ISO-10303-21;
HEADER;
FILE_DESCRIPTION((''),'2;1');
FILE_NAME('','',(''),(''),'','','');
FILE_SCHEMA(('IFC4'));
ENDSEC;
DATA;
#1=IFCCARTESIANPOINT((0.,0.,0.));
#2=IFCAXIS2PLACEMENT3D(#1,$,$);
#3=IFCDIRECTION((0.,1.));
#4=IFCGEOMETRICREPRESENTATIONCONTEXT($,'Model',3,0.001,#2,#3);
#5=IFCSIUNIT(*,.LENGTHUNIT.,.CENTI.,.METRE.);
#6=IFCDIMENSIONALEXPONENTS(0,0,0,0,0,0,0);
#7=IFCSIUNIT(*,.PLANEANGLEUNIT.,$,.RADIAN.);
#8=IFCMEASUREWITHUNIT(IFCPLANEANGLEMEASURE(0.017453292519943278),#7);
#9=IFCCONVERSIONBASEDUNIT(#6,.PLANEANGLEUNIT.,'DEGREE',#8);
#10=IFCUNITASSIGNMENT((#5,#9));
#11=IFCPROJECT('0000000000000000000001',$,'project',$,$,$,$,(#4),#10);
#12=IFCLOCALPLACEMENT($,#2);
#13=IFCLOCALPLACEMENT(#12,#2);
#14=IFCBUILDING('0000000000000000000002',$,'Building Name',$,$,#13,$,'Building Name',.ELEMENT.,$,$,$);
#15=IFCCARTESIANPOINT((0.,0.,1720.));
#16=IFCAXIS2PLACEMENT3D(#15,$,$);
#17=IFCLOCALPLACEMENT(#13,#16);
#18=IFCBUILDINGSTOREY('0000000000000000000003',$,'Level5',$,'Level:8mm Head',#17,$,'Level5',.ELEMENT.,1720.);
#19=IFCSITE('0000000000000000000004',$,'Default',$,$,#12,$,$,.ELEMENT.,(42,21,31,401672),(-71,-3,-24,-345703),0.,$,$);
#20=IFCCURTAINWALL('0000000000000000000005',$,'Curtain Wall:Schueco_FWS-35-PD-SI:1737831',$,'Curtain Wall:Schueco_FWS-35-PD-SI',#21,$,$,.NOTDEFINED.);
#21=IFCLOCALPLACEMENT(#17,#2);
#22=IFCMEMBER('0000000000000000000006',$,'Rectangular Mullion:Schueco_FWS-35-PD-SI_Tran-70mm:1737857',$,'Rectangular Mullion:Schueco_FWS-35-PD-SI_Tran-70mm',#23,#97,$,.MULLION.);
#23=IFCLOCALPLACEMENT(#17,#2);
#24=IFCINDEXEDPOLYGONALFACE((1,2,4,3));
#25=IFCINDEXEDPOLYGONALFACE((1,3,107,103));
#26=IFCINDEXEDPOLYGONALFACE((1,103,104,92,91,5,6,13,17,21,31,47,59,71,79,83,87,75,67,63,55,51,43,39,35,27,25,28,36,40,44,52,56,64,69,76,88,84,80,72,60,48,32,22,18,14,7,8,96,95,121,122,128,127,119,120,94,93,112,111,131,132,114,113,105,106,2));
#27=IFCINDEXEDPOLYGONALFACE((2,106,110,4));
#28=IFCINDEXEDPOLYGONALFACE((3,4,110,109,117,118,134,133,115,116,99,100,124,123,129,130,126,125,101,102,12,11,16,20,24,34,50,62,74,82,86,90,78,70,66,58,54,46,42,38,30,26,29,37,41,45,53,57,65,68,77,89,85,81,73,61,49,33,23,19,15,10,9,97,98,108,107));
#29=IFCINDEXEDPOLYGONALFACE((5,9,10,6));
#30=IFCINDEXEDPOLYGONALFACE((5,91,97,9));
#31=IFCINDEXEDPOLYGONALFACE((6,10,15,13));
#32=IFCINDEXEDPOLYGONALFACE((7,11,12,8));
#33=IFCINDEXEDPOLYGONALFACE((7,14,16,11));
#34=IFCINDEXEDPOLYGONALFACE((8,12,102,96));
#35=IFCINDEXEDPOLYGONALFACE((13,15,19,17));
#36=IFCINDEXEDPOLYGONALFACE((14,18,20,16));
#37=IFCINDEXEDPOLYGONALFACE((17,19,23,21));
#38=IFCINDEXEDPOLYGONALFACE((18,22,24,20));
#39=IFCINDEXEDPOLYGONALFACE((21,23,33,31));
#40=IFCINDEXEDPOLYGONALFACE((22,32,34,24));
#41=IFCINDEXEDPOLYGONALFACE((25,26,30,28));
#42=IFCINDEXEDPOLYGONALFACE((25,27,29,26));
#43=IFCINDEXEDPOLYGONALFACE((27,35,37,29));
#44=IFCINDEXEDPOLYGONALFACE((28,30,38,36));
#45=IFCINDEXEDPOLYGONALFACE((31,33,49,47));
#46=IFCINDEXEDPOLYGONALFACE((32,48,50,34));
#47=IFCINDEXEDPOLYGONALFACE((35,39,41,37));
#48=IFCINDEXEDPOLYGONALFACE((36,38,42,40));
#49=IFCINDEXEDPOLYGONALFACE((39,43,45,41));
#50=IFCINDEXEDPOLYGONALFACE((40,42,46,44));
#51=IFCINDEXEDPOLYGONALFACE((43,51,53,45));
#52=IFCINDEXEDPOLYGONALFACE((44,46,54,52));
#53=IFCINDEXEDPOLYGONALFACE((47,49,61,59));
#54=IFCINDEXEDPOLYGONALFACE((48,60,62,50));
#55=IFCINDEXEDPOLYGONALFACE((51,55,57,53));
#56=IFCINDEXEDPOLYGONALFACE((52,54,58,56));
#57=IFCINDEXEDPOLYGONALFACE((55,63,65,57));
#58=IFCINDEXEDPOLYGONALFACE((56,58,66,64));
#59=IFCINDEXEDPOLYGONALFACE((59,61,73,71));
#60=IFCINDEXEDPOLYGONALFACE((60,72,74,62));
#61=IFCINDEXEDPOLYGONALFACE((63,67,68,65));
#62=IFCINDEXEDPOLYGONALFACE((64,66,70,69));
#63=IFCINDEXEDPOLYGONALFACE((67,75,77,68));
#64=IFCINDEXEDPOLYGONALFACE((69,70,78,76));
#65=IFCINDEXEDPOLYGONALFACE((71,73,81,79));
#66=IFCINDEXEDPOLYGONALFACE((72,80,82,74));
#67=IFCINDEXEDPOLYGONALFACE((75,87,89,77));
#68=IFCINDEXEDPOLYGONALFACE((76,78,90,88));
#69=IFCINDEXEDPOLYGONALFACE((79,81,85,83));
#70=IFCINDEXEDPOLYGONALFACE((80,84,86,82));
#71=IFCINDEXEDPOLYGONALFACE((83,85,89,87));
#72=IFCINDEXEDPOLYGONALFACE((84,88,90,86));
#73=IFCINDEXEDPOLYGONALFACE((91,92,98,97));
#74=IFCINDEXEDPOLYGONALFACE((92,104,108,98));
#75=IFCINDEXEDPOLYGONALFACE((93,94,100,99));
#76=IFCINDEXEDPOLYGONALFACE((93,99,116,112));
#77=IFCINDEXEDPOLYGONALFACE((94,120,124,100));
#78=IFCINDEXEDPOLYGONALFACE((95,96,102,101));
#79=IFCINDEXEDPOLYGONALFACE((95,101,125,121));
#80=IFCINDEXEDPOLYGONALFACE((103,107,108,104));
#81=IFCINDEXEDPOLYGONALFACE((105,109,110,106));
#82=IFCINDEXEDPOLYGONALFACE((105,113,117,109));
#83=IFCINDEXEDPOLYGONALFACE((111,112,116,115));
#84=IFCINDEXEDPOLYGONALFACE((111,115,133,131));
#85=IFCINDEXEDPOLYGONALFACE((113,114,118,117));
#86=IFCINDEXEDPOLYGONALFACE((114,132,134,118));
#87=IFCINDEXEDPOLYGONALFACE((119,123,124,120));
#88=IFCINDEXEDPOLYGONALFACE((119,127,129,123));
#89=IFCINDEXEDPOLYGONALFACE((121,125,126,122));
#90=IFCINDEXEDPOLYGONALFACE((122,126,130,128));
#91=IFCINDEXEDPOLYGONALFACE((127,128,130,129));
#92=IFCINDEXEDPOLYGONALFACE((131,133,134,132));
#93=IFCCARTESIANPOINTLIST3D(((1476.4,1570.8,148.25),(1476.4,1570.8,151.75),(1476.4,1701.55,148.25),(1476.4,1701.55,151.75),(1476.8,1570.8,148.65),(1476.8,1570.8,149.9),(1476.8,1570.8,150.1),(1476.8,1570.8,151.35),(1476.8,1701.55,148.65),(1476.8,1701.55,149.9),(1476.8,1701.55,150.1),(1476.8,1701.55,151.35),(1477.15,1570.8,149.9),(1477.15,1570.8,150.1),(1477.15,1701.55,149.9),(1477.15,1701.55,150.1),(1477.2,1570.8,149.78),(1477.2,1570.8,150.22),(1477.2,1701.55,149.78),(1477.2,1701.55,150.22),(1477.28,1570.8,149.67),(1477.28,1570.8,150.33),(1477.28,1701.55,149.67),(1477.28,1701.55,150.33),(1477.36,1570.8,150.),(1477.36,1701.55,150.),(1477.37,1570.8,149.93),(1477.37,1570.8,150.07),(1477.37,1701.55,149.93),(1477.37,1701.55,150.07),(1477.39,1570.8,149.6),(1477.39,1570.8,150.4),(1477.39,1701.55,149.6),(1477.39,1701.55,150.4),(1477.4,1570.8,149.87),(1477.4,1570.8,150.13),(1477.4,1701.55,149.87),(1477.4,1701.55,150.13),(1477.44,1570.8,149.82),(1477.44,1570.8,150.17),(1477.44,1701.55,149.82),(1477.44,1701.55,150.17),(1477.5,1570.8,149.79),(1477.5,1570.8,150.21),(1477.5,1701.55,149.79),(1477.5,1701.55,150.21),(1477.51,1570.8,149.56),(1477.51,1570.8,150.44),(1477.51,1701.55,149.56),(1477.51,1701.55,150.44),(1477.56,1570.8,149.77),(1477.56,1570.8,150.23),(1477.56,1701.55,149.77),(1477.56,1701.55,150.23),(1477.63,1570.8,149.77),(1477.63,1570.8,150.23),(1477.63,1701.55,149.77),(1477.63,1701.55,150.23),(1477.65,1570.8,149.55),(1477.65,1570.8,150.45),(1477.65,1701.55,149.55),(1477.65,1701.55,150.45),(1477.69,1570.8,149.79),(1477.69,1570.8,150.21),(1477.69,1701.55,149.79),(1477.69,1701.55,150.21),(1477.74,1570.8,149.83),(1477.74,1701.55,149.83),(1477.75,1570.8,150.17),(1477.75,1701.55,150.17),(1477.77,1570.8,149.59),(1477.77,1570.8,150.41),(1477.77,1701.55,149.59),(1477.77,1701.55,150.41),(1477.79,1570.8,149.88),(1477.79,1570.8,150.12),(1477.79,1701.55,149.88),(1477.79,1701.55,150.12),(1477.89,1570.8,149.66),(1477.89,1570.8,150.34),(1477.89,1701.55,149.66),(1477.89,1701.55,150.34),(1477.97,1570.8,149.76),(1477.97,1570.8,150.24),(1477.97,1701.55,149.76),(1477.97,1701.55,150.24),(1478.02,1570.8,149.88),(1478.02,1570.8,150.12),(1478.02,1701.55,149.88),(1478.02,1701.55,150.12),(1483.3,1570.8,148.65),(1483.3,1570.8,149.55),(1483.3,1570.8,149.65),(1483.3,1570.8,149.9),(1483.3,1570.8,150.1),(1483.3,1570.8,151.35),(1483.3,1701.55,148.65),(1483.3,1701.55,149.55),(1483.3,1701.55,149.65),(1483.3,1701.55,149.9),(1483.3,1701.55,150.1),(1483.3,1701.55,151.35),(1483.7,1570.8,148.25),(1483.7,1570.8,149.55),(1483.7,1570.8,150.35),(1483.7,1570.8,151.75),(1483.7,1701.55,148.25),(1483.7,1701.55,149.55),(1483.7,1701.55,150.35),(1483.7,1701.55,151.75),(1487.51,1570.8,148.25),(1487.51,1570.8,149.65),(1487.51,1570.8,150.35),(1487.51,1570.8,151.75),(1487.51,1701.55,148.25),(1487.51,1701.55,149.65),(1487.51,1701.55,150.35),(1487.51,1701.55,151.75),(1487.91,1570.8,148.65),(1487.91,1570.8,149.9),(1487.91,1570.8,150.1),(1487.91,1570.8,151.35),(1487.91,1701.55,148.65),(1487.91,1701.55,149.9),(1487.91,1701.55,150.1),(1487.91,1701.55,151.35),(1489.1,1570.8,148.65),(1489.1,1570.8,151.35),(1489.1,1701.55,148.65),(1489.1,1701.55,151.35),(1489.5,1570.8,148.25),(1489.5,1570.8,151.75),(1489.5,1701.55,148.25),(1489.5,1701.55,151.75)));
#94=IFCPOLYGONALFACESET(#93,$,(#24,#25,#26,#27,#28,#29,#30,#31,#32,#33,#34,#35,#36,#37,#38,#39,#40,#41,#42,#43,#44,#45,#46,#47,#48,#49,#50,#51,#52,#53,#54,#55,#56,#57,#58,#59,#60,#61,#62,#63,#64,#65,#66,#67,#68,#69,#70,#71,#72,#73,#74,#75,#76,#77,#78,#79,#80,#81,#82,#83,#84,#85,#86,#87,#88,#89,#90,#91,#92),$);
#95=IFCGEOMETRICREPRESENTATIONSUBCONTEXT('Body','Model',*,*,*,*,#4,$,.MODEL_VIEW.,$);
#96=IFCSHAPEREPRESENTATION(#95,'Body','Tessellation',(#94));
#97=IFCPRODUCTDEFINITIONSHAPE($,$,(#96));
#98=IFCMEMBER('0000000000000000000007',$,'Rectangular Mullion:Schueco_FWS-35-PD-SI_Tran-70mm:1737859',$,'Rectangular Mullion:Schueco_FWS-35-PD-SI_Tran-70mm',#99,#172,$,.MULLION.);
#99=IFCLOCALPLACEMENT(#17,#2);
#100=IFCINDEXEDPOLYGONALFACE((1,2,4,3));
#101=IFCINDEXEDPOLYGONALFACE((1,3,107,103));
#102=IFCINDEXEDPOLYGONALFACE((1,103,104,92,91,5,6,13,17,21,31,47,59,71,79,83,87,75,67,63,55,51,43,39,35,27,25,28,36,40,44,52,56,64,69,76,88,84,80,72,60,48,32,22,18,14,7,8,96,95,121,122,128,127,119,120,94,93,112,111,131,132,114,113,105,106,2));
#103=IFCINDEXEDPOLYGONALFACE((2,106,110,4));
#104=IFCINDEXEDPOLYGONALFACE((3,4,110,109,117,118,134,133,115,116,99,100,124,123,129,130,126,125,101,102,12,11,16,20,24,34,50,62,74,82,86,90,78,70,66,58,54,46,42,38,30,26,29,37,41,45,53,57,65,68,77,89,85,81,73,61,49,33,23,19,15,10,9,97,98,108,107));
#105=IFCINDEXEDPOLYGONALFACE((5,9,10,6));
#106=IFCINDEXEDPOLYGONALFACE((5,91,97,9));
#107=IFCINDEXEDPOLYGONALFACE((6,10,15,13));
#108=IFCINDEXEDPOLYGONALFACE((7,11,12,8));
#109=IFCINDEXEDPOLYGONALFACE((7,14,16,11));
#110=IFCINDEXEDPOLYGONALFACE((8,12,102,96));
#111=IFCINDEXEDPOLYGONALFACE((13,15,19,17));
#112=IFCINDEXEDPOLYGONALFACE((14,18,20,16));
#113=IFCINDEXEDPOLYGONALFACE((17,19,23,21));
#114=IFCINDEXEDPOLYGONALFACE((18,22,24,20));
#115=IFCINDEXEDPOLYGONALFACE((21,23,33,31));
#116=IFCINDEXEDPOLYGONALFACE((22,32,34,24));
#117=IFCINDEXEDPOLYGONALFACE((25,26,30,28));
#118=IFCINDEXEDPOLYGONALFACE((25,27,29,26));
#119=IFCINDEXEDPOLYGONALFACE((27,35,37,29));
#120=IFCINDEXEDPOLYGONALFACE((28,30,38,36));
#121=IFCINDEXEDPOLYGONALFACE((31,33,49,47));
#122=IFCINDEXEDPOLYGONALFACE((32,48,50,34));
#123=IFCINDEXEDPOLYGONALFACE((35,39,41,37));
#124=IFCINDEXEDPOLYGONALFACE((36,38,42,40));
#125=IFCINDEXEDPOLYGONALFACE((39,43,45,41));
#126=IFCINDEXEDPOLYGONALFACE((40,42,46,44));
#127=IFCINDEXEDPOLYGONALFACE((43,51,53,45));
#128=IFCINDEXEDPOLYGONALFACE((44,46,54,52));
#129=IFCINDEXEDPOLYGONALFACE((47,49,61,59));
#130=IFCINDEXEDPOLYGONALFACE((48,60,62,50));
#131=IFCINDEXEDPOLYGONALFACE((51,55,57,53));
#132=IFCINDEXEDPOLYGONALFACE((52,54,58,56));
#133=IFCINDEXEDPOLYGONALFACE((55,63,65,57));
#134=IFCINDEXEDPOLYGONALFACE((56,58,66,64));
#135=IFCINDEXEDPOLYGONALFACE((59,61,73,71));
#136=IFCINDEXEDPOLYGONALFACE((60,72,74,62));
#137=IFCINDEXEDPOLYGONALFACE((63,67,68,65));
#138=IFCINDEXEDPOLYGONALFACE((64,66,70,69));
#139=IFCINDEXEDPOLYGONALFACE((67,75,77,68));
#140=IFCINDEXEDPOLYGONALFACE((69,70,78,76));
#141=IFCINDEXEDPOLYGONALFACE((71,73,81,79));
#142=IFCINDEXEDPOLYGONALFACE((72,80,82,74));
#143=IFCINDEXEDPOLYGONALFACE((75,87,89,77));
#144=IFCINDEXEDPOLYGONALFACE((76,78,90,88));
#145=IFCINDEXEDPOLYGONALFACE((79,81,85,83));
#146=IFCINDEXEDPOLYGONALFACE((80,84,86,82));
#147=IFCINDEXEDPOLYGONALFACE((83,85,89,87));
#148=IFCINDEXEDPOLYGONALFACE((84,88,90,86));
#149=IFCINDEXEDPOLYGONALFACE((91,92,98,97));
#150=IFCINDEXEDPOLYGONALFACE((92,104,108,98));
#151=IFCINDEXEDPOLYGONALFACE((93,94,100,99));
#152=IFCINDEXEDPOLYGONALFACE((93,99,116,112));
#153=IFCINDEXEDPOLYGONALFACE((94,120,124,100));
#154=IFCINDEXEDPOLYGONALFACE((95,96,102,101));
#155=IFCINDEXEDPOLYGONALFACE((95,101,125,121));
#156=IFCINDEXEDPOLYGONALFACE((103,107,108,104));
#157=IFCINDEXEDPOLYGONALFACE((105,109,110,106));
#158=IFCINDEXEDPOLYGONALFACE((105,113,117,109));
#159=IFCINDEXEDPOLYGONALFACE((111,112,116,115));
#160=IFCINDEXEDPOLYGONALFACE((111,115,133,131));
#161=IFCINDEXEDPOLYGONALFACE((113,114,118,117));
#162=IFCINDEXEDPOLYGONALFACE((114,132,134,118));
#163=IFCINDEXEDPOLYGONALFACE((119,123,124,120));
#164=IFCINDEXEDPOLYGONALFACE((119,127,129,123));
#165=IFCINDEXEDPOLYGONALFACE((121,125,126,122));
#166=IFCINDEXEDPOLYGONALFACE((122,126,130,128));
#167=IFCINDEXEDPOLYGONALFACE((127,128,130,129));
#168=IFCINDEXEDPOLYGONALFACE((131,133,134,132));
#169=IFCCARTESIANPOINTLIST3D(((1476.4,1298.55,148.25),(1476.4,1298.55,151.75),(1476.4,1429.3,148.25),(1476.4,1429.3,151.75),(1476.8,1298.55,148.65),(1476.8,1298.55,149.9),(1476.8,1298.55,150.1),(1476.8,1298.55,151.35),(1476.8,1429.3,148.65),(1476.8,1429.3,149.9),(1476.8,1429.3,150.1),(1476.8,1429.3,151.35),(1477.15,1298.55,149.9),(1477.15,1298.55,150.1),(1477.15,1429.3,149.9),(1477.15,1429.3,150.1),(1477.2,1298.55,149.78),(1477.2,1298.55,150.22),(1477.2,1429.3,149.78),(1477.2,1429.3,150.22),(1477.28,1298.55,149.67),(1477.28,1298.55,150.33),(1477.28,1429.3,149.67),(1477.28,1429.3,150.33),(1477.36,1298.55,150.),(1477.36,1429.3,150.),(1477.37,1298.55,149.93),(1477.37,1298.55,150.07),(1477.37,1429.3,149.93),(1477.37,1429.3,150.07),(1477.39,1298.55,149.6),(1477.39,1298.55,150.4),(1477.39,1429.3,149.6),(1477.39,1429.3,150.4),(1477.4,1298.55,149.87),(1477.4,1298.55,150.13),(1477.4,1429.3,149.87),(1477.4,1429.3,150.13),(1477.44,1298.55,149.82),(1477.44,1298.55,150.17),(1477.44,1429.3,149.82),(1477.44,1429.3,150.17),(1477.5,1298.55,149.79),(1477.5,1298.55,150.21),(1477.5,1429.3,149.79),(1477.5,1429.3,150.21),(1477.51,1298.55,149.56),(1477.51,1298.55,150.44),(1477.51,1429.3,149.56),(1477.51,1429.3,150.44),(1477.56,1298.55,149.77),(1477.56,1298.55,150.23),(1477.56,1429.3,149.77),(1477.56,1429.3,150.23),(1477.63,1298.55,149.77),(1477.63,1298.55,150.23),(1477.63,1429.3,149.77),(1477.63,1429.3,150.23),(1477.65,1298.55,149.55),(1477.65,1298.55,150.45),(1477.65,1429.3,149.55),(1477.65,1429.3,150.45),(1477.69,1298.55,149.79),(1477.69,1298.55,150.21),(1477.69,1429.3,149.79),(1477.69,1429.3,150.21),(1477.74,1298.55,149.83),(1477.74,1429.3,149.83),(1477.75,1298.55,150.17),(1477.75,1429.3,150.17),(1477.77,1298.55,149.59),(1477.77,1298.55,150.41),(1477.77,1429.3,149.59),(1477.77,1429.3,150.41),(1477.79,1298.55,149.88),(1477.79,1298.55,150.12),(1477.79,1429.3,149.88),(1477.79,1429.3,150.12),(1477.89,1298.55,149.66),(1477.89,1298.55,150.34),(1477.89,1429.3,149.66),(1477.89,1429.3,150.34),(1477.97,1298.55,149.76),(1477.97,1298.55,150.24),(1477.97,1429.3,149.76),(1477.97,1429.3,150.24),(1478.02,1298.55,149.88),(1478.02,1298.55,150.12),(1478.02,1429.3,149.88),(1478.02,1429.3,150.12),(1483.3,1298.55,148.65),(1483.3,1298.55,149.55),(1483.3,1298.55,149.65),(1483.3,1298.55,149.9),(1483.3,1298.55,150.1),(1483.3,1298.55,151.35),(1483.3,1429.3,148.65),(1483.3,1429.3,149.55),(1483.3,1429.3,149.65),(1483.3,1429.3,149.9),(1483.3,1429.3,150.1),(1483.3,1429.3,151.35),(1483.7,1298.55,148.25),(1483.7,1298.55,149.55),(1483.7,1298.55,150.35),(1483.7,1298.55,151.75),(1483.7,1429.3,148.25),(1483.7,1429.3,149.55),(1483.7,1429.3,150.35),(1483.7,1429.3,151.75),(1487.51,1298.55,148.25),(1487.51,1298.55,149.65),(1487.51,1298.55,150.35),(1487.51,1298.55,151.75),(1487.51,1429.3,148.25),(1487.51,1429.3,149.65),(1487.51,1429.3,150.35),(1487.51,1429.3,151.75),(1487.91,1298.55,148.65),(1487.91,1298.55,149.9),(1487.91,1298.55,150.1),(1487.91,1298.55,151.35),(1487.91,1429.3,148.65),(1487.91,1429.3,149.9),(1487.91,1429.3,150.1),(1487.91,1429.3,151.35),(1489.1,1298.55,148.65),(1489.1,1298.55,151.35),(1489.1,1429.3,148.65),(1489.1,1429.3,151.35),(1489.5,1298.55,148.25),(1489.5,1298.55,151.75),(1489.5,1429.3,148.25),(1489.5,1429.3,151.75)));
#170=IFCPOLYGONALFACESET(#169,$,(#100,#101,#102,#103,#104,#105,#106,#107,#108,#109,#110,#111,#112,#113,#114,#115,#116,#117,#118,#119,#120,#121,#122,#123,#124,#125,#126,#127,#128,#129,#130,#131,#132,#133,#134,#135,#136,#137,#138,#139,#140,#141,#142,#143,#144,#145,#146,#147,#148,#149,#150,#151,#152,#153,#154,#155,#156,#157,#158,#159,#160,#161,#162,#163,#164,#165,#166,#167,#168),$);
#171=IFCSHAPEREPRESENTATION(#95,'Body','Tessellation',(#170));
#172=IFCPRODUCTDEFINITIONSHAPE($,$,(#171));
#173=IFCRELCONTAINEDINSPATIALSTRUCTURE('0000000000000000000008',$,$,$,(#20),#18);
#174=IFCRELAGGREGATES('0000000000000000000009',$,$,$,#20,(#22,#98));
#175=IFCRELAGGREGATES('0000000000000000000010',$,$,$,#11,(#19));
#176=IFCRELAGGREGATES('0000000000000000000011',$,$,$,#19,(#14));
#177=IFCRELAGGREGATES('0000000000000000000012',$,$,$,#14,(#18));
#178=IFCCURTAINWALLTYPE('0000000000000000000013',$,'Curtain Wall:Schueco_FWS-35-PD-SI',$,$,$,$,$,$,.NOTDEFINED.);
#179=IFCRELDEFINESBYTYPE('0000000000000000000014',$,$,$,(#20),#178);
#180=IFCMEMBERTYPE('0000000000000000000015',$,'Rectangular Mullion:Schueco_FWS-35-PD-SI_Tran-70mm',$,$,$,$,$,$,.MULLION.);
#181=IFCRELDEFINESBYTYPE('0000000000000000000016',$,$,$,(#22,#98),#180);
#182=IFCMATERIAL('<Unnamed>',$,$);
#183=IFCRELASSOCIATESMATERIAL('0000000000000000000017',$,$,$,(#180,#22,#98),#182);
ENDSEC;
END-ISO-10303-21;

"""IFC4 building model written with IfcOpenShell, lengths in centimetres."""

from ifc_helpers import new_model, entity, si_unit, converted_unit, direction, frame, origin, place, context, subcontext, project, spatial, line, arc, indexed_curve, outline, extrude, source, transform, mapped, material, type_object, type_shapes, element, aggregate, save


model = new_model("IFC4")

# Units and contexts
model_context = context("Model", 3, precision=0.001, world=origin(), true_north=direction((0.0, 1.0)))
body_context = subcontext(model_context, "Body", "Model", "MODEL_VIEW")
ifc_project = project(units=[si_unit("LENGTHUNIT", "METRE", prefix="CENTI"), converted_unit("PLANEANGLEUNIT", "DEGREE", entity("IfcPlaneAngleMeasure", 0.017453292519943278), si_unit("PLANEANGLEUNIT", "RADIAN"), dimensions=[0, 0, 0, 0, 0, 0, 0])], contexts=[model_context])

# Site, building, storey
site_placement = place(None, origin())
site = spatial("IfcSite", under=ifc_project, at=site_placement, Name="Default", CompositionType="ELEMENT", RefLatitude=(42, 21, 31, 401672), RefLongitude=(-71, -3, -24, -345703), RefElevation=0.0)
building_placement = place(site_placement, origin())
building = spatial("IfcBuilding", under=site, at=building_placement, Name="Building Name", LongName="Building Name", CompositionType="ELEMENT")
storey_placement = place(building_placement, frame((0.0, 0.0, 1720.0)))
storey = spatial("IfcBuildingStorey", under=building, at=storey_placement, Name="Level5", ObjectType="Level:8mm Head", LongName="Level5", CompositionType="ELEMENT", Elevation=1720.0)

# Curtain wall, members
curtain_wall_type = type_object("IfcCurtainWallType", Name="Curtain Wall:Schueco_FWS-35-PD-SI", PredefinedType="NOTDEFINED")
curtain_wall_placement = place(storey_placement, frame((0.0, 0.0, -1720.0)))
curtain_wall = element("IfcCurtainWall", 1, at=curtain_wall_placement, inside=storey, type_object=curtain_wall_type, Name="Curtain Wall:Schueco_FWS-35-PD-SI:1737831", ObjectType="Curtain Wall:Schueco_FWS-35-PD-SI", PredefinedType="NOTDEFINED")
ifc_material_1 = material(Name="<Unnamed>")
member_type_1 = type_object("IfcMemberType", Name="Rectangular Mullion:Schueco_FWS-35-PD-SI_Tran-70mm", PredefinedType="MULLION", material=ifc_material_1)
shared_shape_1 = source(origin(), body_context, "Body", "SweptSolid", [
    extrude(outline(indexed_curve([(-1.78, -6.52), (1.72, -6.52), (1.72, 0.78), (0.42, 0.78), (0.42, 0.38), (1.32, 0.38), (1.32, -6.12), (0.07, -6.12), (0.07, -5.77), (0.42, -5.34), (0.09, -4.9), (0.09, -5.14), (-0.03, -5.56), (-0.15, -5.14), (-0.15, -4.9), (-0.48, -5.34), (-0.13, -5.77), (-0.13, -6.12), (-1.38, -6.12), (-1.38, 0.38), (-0.13, 0.38), (-0.13, 4.99), (-1.38, 4.99), (-1.38, 6.18), (1.32, 6.18), (1.32, 4.99), (0.07, 4.99), (0.07, 0.38), (0.32, 0.38), (0.32, 4.59), (1.72, 4.59), (1.72, 6.58), (-1.78, 6.58), (-1.78, 4.59), (-0.38, 4.59), (-0.38, 0.78), (-1.78, 0.78)], segments=[line(1, 2, 3, 4, 5, 6, 7, 8, 9), arc(9, 10, 11), line(11, 12), arc(12, 13, 14), line(14, 15), arc(15, 16, 17), line(17, 18, 19, 20, 21, 22, 23, 24, 25, 26, 27, 28, 29, 30, 31, 32, 33, 34, 35, 36, 37, 1)], self_intersect=False)), frame((-0.03, 4.58, -130.75), z_axis=(0.0, 0.0, 1.0), x_axis=(-1.0, 0.0, 0.0)), (0.0, 0.0, 1.0), 130.75),
])
type_shapes(member_type_1, [shared_shape_1])
member_1_placement = place(curtain_wall_placement, frame((1487.5, 1570.8, 1870.0), z_axis=(0.0, -1.0, 0.0), x_axis=(0.0, 0.0, 1.0)))
member_1 = element("IfcMember", 2, at=member_1_placement, type_object=member_type_1, material=ifc_material_1, Name="Rectangular Mullion:Schueco_FWS-35-PD-SI_Tran-70mm:1737857", ObjectType="Rectangular Mullion:Schueco_FWS-35-PD-SI_Tran-70mm", PredefinedType="MULLION", context=body_context, shape_type="MappedRepresentation", body=[
    mapped(shared_shape_1, transform((0.0, 0.0, 0.0), scale=1.0)),
])
member_2_placement = place(curtain_wall_placement, frame((1487.5, 1298.55, 1870.0), z_axis=(0.0, -1.0, 0.0), x_axis=(0.0, 0.0, 1.0)))
member_2 = element("IfcMember", 3, at=member_2_placement, type_object=member_type_1, material=ifc_material_1, Name="Rectangular Mullion:Schueco_FWS-35-PD-SI_Tran-70mm:1737859", ObjectType="Rectangular Mullion:Schueco_FWS-35-PD-SI_Tran-70mm", PredefinedType="MULLION", context=body_context, shape_type="MappedRepresentation", body=[
    mapped(shared_shape_1, transform((0.0, 0.0, 0.0), scale=1.0)),
])
aggregate(curtain_wall, [member_1, member_2])

save(model, "model.ifc")
